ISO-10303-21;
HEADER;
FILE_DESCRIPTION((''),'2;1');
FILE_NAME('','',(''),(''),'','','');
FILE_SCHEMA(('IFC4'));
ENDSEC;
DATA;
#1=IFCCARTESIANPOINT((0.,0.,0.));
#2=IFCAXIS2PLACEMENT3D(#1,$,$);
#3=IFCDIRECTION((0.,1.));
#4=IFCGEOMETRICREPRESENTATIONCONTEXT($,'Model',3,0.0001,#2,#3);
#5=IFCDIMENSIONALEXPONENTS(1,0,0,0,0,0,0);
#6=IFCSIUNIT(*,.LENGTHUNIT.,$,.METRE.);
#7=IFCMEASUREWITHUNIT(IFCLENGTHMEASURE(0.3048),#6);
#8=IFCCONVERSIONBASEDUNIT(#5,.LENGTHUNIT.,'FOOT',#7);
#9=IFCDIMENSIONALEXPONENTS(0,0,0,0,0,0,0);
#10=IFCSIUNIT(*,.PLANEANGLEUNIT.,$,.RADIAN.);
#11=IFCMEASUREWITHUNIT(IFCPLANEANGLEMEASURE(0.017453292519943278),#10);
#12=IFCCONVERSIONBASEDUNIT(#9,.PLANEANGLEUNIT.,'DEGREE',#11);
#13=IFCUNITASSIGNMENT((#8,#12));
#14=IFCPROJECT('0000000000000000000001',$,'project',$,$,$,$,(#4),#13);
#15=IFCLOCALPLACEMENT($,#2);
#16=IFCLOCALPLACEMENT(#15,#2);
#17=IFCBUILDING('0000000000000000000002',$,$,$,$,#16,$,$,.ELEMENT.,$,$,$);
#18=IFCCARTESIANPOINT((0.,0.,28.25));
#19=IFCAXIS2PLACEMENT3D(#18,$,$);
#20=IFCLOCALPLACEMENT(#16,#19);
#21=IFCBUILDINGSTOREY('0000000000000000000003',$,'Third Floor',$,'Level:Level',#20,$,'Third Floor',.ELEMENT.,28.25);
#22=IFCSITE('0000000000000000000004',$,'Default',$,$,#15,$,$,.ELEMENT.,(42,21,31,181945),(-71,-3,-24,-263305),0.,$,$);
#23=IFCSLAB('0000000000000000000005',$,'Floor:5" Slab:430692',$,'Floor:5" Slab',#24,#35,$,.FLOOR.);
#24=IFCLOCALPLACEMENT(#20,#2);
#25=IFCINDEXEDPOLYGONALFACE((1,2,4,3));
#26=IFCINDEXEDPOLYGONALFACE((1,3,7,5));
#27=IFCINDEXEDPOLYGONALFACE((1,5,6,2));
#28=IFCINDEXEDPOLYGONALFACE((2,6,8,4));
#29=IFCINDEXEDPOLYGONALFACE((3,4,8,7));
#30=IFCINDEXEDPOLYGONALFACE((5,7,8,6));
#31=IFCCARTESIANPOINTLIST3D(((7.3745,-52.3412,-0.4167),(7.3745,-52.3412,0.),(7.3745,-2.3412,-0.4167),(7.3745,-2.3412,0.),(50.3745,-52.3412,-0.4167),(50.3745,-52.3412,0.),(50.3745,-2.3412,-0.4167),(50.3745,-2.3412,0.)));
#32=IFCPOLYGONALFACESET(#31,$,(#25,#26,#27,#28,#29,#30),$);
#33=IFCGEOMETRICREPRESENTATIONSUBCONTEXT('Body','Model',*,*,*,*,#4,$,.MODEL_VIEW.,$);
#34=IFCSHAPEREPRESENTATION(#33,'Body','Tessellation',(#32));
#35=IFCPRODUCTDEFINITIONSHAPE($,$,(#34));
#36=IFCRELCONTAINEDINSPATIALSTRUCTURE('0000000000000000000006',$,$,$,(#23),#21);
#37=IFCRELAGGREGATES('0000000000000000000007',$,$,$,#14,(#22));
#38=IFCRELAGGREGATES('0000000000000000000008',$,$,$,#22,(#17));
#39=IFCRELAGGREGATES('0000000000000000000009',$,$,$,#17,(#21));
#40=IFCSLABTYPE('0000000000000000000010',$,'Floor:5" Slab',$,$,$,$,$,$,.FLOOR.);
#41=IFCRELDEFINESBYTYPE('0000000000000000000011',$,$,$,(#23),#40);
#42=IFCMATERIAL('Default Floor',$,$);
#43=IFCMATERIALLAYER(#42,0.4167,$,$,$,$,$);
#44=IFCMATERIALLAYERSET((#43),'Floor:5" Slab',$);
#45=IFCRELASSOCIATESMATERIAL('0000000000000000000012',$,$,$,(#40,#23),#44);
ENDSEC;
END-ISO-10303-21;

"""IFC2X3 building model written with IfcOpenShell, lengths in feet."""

from ifc_helpers import new_model, entity, si_unit, converted_unit, direction, frame, origin, origin_2d_with_axis, place, context, subcontext, project, spatial, rectangle, extrude, material, layer, layer_set, layer_usage, type_object, element, save


model = new_model("IFC2X3")

# Units and contexts
model_context = context("Model", 3, precision=0.0001, world=origin(), true_north=direction((0.0, 1.0)))
body_context = subcontext(model_context, "Body", "Model", "MODEL_VIEW")
ifc_project = project(units=[converted_unit("LENGTHUNIT", "FOOT", entity("IfcLengthMeasure", 0.3048), si_unit("LENGTHUNIT", "METRE"), dimensions=[1, 0, 0, 0, 0, 0, 0]), converted_unit("PLANEANGLEUNIT", "DEGREE", entity("IfcPlaneAngleMeasure", 0.017453292519943278), si_unit("PLANEANGLEUNIT", "RADIAN"), dimensions=[0, 0, 0, 0, 0, 0, 0])], contexts=[model_context])

# Site, building, storey
site_placement = place(None, origin())
site = spatial("IfcSite", under=ifc_project, at=site_placement, Name="Default", CompositionType="ELEMENT", RefLatitude=(42, 21, 31, 181945), RefLongitude=(-71, -3, -24, -263305), RefElevation=0.0)
building_placement = place(site_placement, origin())
building = spatial("IfcBuilding", under=site, at=building_placement, CompositionType="ELEMENT")
storey_placement = place(building_placement, frame((0.0, 0.0, 28.25)))
storey = spatial("IfcBuildingStorey", under=building, at=storey_placement, Name="Third Floor", ObjectType="Level:Level", LongName="Third Floor", CompositionType="ELEMENT", Elevation=28.25)

# Slab
ifc_material = material(Name="Default Floor")
ifc_layer = layer(ifc_material, 0.4167)
ifc_layer_set = layer_set([ifc_layer], Name="Floor:5\" Slab")
ifc_layer_usage = layer_usage(ifc_layer_set, "AXIS3", "POSITIVE", 0.0)
slab_type = type_object("IfcSlabType", Name="Floor:5\" Slab", PredefinedType="FLOOR", material=ifc_layer_set)
slab_placement = place(storey_placement, origin())
element("IfcSlab", 1, at=slab_placement, inside=storey, type_object=slab_type, material=ifc_layer_usage, Name="Floor:5\" Slab:430692", ObjectType="Floor:5\" Slab", PredefinedType="FLOOR", context=body_context, shape_type="SweptSolid", body=[
    extrude(rectangle(XDim=50.0, YDim=43.0, at=origin_2d_with_axis()), frame((28.8745, -27.3412, 0.0), z_axis=(0.0, 0.0, -1.0), x_axis=(0.0, 1.0, 0.0)), (0.0, 0.0, 1.0), 0.4167),
])

save(model, "model.ifc")
